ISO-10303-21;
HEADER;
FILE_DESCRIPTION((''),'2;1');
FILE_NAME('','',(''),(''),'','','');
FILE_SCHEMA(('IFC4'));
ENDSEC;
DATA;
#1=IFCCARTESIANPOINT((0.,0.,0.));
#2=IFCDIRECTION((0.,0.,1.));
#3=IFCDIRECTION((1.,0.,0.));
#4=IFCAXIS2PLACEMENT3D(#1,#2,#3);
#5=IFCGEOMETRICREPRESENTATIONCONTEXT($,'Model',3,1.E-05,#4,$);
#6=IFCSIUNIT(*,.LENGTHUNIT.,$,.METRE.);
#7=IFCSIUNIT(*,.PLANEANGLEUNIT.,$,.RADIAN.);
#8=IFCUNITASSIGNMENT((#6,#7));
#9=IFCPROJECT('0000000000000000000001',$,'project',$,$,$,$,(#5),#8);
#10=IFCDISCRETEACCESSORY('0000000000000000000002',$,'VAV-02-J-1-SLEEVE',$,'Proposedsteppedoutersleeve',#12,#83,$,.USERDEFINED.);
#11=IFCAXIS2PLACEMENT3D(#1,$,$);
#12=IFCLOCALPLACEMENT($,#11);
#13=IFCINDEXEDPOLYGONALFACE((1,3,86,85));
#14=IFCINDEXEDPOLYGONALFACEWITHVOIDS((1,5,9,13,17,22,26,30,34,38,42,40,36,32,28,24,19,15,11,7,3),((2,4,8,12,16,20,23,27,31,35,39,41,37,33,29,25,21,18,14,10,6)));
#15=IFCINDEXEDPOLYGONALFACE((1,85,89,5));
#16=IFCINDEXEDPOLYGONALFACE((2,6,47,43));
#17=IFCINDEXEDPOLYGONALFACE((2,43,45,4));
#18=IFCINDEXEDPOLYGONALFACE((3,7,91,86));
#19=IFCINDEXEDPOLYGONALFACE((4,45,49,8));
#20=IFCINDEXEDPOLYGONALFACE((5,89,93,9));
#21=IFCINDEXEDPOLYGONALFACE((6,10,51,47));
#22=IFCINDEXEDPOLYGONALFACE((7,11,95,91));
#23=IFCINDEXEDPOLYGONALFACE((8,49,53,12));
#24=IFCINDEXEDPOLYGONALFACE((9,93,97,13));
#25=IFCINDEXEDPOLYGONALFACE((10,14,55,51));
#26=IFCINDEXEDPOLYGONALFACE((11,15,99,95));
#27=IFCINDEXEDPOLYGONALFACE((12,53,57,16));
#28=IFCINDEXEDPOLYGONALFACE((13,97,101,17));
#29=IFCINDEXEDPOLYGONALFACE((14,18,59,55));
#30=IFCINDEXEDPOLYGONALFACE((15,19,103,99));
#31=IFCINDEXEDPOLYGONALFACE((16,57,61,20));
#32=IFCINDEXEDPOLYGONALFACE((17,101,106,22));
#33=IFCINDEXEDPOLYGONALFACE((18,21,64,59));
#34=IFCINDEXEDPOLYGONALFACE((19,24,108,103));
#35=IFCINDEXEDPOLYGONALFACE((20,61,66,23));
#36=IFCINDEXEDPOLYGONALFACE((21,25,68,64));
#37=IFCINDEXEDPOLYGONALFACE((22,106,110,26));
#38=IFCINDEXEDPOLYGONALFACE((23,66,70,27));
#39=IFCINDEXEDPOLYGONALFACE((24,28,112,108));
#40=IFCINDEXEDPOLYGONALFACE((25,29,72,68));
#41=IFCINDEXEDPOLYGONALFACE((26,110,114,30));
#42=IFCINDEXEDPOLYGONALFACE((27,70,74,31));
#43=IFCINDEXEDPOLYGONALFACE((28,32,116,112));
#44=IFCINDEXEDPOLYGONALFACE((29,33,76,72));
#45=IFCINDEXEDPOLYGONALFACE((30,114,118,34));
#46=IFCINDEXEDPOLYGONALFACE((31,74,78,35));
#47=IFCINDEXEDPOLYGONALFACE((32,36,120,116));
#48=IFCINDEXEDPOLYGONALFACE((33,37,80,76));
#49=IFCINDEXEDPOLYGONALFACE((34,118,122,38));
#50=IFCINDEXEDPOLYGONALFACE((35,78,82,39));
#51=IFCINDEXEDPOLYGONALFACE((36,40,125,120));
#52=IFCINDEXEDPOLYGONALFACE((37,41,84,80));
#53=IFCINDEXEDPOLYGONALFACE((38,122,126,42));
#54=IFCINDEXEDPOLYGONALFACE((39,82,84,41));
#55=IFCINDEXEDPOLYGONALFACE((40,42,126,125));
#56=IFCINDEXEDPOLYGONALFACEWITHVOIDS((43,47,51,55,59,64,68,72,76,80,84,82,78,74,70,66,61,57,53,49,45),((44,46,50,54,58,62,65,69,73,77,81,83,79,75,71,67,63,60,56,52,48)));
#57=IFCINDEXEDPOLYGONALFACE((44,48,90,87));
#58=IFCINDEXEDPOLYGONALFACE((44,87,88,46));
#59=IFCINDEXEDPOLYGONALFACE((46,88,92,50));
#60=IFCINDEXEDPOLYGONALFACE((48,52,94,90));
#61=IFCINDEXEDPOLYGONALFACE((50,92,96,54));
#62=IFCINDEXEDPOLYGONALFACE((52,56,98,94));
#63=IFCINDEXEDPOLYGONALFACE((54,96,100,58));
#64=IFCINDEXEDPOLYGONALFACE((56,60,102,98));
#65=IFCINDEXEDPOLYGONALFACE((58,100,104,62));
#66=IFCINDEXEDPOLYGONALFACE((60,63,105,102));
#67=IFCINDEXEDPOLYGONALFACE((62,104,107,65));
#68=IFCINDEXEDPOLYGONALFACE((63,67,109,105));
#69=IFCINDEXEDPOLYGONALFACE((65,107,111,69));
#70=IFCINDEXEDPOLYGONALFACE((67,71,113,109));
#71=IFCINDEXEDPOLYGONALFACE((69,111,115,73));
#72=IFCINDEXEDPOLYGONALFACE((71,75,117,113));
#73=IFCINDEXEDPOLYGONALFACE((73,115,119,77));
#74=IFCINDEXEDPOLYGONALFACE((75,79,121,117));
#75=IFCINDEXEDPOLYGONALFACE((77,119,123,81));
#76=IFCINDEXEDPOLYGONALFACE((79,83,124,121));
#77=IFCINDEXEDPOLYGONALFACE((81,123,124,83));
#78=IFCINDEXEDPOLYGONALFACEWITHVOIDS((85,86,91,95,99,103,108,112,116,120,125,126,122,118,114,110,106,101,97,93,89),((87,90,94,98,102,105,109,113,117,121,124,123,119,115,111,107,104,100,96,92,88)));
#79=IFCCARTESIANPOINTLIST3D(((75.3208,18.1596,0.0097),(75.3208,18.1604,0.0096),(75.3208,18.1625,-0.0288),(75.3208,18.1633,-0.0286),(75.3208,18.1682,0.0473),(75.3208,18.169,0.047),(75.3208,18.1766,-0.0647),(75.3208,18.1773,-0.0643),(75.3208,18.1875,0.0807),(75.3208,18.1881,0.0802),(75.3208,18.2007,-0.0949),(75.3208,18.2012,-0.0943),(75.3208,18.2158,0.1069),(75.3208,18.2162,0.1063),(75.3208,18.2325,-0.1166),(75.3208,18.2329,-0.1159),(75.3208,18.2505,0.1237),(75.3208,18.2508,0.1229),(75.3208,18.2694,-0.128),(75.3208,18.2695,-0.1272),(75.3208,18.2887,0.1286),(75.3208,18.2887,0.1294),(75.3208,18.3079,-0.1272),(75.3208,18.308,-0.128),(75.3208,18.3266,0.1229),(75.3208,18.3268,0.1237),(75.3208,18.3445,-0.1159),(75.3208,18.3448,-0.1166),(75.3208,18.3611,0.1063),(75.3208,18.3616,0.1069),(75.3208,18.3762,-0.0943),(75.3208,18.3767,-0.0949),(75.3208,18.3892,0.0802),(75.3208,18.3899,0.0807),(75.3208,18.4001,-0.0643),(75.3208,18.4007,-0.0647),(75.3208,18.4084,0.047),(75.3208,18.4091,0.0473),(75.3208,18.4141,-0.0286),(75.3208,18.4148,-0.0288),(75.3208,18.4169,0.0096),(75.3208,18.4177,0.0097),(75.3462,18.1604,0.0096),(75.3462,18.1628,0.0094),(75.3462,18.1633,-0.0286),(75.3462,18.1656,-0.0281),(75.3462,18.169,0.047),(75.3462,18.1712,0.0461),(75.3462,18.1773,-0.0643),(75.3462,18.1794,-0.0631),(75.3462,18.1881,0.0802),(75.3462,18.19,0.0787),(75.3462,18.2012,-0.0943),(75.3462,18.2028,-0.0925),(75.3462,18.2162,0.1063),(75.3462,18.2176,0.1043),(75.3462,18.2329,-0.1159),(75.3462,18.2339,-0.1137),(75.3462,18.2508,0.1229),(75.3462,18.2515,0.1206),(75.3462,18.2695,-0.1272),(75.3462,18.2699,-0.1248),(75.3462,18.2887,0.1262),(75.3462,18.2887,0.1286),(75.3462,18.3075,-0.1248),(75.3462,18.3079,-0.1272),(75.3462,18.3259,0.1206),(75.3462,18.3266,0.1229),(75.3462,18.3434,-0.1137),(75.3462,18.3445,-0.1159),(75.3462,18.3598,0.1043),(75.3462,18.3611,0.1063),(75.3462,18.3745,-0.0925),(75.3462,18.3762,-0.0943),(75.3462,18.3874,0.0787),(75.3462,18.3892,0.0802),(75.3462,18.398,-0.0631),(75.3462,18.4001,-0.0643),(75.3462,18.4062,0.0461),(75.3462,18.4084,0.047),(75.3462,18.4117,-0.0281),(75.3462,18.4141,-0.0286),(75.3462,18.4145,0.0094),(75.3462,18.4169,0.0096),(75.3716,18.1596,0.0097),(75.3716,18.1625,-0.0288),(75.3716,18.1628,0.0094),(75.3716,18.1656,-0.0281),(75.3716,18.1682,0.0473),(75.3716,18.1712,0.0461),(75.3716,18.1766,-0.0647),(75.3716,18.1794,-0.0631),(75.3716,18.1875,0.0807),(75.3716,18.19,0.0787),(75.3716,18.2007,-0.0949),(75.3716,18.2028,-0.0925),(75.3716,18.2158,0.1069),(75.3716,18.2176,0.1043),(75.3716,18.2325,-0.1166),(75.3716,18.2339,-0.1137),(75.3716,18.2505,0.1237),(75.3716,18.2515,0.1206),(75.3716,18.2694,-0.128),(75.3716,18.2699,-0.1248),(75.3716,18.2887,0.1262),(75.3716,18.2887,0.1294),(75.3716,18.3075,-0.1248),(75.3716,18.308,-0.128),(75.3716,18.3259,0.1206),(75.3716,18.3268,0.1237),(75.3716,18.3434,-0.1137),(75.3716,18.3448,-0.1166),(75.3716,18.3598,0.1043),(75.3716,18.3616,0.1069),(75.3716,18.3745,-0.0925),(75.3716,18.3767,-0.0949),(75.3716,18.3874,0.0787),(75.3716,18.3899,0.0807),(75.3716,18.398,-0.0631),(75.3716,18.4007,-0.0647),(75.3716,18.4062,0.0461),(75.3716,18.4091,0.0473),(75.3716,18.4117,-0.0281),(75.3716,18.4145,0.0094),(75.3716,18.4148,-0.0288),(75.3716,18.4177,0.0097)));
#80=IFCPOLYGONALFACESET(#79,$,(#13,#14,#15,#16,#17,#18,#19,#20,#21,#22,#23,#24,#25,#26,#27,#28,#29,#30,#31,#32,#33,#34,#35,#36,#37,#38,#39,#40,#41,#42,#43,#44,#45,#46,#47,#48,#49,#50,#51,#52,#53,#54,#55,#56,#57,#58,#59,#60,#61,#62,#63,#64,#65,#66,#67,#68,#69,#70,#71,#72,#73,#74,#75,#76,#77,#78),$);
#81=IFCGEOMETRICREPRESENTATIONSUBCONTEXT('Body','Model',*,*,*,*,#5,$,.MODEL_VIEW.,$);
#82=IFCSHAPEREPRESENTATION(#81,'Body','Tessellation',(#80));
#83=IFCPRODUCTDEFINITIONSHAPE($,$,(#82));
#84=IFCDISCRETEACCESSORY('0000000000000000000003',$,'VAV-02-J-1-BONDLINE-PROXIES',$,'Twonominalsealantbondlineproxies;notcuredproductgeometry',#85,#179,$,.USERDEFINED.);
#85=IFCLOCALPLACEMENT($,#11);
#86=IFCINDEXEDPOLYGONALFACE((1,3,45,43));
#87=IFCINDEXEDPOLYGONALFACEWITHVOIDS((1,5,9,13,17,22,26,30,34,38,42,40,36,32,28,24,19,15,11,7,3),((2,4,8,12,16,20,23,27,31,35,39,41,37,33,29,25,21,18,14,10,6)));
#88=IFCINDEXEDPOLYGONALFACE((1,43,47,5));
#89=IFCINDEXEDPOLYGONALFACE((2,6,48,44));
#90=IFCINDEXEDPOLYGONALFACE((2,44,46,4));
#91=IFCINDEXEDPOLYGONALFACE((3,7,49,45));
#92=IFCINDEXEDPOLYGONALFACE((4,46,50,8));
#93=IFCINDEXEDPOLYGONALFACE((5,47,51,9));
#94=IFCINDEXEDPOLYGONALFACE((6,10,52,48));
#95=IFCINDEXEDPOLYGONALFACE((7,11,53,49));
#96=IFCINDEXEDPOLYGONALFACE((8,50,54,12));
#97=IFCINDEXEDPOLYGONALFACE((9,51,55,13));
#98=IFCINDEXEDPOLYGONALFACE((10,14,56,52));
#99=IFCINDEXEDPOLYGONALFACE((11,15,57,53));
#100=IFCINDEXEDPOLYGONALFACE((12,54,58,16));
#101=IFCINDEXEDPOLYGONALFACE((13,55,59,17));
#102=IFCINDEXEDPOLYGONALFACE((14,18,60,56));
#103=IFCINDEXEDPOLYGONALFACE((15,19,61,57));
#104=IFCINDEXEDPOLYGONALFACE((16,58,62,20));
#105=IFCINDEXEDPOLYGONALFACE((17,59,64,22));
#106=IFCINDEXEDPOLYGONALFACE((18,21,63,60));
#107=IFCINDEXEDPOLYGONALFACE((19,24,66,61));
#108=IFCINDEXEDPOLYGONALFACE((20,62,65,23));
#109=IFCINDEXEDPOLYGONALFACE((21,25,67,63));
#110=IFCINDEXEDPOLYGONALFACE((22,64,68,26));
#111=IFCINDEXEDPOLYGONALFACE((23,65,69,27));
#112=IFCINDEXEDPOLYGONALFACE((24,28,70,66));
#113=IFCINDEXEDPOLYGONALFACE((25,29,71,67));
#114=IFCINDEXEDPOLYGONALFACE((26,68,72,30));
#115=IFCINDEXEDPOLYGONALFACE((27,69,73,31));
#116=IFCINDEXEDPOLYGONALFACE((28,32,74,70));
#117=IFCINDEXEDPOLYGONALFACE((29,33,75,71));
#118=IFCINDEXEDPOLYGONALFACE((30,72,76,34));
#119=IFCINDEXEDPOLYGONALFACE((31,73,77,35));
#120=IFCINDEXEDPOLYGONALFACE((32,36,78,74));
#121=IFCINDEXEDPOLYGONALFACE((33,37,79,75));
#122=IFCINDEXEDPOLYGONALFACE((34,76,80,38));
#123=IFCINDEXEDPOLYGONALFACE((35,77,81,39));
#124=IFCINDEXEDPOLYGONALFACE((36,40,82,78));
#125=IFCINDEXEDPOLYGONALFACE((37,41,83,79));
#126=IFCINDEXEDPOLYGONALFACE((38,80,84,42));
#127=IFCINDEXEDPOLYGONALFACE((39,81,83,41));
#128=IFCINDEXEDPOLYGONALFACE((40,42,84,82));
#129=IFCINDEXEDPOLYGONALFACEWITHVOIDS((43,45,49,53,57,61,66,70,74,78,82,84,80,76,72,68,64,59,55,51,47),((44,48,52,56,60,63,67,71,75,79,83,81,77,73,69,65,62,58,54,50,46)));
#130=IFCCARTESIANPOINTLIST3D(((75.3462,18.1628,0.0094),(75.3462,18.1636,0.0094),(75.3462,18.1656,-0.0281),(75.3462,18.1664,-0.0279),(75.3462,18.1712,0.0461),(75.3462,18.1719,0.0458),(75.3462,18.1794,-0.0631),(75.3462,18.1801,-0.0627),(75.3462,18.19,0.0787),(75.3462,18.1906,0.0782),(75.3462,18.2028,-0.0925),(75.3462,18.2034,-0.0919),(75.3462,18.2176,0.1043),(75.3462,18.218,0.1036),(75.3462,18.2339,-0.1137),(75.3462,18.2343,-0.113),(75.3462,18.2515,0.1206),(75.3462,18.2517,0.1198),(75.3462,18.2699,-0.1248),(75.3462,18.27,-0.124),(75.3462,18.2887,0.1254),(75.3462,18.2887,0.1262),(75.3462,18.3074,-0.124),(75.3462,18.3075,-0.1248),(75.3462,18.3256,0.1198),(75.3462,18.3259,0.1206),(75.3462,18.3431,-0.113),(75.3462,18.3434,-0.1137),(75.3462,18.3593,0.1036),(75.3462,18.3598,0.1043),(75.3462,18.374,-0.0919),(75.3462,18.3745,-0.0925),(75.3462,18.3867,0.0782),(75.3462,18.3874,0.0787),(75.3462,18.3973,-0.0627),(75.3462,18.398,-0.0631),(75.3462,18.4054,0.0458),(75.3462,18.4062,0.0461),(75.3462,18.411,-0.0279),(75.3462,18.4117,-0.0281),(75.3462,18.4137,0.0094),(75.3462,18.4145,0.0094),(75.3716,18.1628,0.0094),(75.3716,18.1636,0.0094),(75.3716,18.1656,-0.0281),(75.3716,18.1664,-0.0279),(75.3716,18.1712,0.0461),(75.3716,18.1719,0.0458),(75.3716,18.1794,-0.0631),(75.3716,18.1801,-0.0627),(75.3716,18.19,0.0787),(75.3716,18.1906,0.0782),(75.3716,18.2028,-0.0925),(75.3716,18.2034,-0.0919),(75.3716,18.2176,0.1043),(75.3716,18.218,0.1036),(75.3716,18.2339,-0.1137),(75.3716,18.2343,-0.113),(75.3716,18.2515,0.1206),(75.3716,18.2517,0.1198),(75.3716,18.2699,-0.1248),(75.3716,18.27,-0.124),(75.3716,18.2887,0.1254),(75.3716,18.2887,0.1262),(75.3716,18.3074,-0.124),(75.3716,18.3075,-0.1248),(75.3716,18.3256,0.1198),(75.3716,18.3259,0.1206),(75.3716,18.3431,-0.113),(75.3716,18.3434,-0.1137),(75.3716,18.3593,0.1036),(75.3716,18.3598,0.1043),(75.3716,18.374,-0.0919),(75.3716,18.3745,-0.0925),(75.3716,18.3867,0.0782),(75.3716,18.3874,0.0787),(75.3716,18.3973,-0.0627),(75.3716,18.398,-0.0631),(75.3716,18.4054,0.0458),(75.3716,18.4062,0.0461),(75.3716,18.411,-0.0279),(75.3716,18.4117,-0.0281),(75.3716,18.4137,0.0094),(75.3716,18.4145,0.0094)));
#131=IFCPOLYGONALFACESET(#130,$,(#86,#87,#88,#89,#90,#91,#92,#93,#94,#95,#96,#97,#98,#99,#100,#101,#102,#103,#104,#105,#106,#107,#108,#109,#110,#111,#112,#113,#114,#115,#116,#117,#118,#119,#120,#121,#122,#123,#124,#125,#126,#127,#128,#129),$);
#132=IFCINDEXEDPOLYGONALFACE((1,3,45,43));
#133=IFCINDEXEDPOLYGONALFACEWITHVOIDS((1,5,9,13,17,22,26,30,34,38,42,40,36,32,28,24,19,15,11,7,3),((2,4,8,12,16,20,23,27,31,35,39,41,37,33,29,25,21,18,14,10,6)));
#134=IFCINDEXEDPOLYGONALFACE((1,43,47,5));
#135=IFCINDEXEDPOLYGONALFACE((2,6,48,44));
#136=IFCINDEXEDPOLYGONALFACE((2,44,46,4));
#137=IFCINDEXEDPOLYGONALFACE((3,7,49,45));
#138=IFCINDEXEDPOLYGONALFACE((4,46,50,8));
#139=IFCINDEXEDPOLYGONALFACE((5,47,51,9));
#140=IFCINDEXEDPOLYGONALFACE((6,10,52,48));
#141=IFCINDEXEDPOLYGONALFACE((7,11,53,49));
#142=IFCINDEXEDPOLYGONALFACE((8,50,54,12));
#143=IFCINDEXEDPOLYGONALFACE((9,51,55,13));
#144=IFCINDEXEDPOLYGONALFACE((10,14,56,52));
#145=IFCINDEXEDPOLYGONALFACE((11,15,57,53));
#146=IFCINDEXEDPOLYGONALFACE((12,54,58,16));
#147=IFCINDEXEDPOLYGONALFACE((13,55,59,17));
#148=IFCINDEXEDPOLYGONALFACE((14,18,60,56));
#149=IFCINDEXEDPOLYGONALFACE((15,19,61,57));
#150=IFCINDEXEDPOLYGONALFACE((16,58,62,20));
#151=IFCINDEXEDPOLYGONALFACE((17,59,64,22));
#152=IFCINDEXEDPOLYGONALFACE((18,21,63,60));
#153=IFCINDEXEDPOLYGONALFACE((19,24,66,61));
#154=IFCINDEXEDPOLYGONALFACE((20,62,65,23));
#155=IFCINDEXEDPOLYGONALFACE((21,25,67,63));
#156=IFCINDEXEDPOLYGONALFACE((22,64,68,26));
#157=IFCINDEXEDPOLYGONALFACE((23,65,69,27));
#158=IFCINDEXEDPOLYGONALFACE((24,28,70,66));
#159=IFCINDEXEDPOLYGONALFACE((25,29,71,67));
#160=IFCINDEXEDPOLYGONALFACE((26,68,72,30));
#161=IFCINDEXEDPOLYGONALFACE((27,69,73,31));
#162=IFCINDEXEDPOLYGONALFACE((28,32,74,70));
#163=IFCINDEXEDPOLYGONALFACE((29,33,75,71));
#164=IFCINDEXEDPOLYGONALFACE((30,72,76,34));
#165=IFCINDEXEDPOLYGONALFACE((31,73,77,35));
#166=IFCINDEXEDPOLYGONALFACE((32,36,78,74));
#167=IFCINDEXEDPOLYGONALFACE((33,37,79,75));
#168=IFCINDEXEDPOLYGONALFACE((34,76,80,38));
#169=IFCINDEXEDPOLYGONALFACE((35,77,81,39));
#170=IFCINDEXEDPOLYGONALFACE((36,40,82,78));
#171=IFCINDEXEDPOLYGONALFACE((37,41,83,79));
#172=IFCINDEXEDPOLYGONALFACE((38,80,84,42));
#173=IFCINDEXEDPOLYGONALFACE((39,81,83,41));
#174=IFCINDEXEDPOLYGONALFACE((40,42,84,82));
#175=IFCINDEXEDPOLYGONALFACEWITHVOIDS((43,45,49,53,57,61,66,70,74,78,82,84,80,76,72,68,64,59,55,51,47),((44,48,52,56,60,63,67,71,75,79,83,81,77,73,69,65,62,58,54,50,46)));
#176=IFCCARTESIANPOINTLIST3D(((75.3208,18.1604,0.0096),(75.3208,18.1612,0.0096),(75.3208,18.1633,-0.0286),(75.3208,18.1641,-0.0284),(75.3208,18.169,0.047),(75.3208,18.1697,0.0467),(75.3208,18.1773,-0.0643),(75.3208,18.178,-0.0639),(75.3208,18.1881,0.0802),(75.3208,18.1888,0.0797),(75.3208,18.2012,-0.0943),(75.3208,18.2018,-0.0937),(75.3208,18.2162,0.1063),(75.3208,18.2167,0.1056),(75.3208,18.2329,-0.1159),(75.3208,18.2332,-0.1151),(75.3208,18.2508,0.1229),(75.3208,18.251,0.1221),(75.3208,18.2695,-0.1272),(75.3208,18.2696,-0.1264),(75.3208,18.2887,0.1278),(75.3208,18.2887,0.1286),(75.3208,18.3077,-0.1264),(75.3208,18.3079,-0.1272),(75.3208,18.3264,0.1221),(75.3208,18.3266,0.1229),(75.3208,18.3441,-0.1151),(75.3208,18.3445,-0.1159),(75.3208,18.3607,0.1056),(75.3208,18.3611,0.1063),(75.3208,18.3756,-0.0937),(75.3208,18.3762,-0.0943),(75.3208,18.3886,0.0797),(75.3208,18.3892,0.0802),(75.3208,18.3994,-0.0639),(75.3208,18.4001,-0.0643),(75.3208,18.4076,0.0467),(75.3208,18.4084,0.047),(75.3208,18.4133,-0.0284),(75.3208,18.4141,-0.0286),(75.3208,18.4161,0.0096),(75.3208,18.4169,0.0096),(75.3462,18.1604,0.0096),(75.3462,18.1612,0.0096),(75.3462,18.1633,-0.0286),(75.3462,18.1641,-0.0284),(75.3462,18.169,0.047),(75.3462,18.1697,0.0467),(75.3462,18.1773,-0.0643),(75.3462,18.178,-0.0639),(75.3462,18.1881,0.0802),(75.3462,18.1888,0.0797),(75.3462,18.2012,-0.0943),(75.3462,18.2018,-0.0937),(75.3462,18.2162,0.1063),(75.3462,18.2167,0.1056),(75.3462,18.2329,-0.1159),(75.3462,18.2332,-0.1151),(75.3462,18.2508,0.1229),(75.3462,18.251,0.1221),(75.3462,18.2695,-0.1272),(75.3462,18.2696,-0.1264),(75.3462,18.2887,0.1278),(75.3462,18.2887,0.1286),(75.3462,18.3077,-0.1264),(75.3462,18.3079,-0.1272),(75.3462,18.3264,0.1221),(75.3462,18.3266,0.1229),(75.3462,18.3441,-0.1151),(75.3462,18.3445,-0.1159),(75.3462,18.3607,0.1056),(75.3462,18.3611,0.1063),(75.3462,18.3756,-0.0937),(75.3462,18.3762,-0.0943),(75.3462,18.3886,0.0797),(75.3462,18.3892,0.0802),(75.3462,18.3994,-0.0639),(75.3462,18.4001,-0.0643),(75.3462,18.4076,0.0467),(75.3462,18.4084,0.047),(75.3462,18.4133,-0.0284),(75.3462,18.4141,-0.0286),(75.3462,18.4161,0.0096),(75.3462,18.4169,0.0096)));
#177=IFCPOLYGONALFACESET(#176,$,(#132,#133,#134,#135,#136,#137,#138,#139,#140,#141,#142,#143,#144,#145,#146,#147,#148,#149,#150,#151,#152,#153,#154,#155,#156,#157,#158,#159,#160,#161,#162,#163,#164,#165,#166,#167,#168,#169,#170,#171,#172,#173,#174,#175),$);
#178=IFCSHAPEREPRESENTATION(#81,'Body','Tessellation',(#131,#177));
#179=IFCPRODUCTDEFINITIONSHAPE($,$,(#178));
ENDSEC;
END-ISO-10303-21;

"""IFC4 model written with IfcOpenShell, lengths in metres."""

from ifc_helpers import new_model, entity, si_unit, frame, origin_with_axes, place, context, subcontext, project, element, save


model = new_model("IFC4")

# Units and contexts
model_context = context("Model", 3, precision=1e-05, world=origin_with_axes())
body_context = subcontext(model_context, "Body", "Model", "MODEL_VIEW")
ifc_project = project(units=[si_unit("LENGTHUNIT", "METRE"), si_unit("PLANEANGLEUNIT", "RADIAN")], contexts=[model_context])

# Discrete accessories
discrete_accessory_1_placement = place(None, frame((75.3462, 18.2887, 0.0), z_axis=(0.0, -1.0, 0.0), x_axis=(0.0, 0.0, 1.0)))
element("IfcDiscreteAccessory", 1, at=discrete_accessory_1_placement, Name="VAV-02-J-1-SLEEVE", ObjectType="Proposedsteppedoutersleeve", PredefinedType="USERDEFINED", context=body_context, shape_type="SweptSolid", body=[
    entity("IfcRevolvedAreaSolid", entity("IfcArbitraryClosedProfileDef", "AREA", None, entity("IfcPolyline", [entity("IfcCartesianPoint", [0.1262, -0.0254]), entity("IfcCartesianPoint", [0.1294, -0.0254]), entity("IfcCartesianPoint", [0.1294, 0.0254]), entity("IfcCartesianPoint", [0.1286, 0.0254]), entity("IfcCartesianPoint", [0.1286, 0.0]), entity("IfcCartesianPoint", [0.1262, 0.0]), entity("IfcCartesianPoint", [0.1262, -0.0254])])), entity("IfcAxis2Placement3D", entity("IfcCartesianPoint", [0.0, 0.0, 0.0])), entity("IfcAxis1Placement", entity("IfcCartesianPoint", [0.0, 0.0, 0.0]), entity("IfcDirection", [0.0, 1.0, 0.0])), 6.283185),
])
discrete_accessory_2_placement = place(None, frame((75.3462, 18.2887, 0.0), z_axis=(0.0, -1.0, 0.0), x_axis=(0.0, 0.0, 1.0)))
element("IfcDiscreteAccessory", 2, at=discrete_accessory_2_placement, Name="VAV-02-J-1-BONDLINE-PROXIES", ObjectType="Twonominalsealantbondlineproxies;notcuredproductgeometry", PredefinedType="USERDEFINED", context=body_context, shape_type="SweptSolid", body=[
    entity("IfcRevolvedAreaSolid", entity("IfcArbitraryClosedProfileDef", "AREA", None, entity("IfcPolyline", [entity("IfcCartesianPoint", [0.1254, -0.0254]), entity("IfcCartesianPoint", [0.1262, -0.0254]), entity("IfcCartesianPoint", [0.1262, 0.0]), entity("IfcCartesianPoint", [0.1254, 0.0]), entity("IfcCartesianPoint", [0.1254, -0.0254])])), entity("IfcAxis2Placement3D", entity("IfcCartesianPoint", [0.0, 0.0, 0.0])), entity("IfcAxis1Placement", entity("IfcCartesianPoint", [0.0, 0.0, 0.0]), entity("IfcDirection", [0.0, 1.0, 0.0])), 6.283185),
    entity("IfcRevolvedAreaSolid", entity("IfcArbitraryClosedProfileDef", "AREA", None, entity("IfcPolyline", [entity("IfcCartesianPoint", [0.1278, 0.0]), entity("IfcCartesianPoint", [0.1286, 0.0]), entity("IfcCartesianPoint", [0.1286, 0.0254]), entity("IfcCartesianPoint", [0.1278, 0.0254]), entity("IfcCartesianPoint", [0.1278, 0.0])])), entity("IfcAxis2Placement3D", entity("IfcCartesianPoint", [0.0, 0.0, 0.0])), entity("IfcAxis1Placement", entity("IfcCartesianPoint", [0.0, 0.0, 0.0]), entity("IfcDirection", [0.0, 1.0, 0.0])), 6.283185),
])

save(model, "model.ifc")
